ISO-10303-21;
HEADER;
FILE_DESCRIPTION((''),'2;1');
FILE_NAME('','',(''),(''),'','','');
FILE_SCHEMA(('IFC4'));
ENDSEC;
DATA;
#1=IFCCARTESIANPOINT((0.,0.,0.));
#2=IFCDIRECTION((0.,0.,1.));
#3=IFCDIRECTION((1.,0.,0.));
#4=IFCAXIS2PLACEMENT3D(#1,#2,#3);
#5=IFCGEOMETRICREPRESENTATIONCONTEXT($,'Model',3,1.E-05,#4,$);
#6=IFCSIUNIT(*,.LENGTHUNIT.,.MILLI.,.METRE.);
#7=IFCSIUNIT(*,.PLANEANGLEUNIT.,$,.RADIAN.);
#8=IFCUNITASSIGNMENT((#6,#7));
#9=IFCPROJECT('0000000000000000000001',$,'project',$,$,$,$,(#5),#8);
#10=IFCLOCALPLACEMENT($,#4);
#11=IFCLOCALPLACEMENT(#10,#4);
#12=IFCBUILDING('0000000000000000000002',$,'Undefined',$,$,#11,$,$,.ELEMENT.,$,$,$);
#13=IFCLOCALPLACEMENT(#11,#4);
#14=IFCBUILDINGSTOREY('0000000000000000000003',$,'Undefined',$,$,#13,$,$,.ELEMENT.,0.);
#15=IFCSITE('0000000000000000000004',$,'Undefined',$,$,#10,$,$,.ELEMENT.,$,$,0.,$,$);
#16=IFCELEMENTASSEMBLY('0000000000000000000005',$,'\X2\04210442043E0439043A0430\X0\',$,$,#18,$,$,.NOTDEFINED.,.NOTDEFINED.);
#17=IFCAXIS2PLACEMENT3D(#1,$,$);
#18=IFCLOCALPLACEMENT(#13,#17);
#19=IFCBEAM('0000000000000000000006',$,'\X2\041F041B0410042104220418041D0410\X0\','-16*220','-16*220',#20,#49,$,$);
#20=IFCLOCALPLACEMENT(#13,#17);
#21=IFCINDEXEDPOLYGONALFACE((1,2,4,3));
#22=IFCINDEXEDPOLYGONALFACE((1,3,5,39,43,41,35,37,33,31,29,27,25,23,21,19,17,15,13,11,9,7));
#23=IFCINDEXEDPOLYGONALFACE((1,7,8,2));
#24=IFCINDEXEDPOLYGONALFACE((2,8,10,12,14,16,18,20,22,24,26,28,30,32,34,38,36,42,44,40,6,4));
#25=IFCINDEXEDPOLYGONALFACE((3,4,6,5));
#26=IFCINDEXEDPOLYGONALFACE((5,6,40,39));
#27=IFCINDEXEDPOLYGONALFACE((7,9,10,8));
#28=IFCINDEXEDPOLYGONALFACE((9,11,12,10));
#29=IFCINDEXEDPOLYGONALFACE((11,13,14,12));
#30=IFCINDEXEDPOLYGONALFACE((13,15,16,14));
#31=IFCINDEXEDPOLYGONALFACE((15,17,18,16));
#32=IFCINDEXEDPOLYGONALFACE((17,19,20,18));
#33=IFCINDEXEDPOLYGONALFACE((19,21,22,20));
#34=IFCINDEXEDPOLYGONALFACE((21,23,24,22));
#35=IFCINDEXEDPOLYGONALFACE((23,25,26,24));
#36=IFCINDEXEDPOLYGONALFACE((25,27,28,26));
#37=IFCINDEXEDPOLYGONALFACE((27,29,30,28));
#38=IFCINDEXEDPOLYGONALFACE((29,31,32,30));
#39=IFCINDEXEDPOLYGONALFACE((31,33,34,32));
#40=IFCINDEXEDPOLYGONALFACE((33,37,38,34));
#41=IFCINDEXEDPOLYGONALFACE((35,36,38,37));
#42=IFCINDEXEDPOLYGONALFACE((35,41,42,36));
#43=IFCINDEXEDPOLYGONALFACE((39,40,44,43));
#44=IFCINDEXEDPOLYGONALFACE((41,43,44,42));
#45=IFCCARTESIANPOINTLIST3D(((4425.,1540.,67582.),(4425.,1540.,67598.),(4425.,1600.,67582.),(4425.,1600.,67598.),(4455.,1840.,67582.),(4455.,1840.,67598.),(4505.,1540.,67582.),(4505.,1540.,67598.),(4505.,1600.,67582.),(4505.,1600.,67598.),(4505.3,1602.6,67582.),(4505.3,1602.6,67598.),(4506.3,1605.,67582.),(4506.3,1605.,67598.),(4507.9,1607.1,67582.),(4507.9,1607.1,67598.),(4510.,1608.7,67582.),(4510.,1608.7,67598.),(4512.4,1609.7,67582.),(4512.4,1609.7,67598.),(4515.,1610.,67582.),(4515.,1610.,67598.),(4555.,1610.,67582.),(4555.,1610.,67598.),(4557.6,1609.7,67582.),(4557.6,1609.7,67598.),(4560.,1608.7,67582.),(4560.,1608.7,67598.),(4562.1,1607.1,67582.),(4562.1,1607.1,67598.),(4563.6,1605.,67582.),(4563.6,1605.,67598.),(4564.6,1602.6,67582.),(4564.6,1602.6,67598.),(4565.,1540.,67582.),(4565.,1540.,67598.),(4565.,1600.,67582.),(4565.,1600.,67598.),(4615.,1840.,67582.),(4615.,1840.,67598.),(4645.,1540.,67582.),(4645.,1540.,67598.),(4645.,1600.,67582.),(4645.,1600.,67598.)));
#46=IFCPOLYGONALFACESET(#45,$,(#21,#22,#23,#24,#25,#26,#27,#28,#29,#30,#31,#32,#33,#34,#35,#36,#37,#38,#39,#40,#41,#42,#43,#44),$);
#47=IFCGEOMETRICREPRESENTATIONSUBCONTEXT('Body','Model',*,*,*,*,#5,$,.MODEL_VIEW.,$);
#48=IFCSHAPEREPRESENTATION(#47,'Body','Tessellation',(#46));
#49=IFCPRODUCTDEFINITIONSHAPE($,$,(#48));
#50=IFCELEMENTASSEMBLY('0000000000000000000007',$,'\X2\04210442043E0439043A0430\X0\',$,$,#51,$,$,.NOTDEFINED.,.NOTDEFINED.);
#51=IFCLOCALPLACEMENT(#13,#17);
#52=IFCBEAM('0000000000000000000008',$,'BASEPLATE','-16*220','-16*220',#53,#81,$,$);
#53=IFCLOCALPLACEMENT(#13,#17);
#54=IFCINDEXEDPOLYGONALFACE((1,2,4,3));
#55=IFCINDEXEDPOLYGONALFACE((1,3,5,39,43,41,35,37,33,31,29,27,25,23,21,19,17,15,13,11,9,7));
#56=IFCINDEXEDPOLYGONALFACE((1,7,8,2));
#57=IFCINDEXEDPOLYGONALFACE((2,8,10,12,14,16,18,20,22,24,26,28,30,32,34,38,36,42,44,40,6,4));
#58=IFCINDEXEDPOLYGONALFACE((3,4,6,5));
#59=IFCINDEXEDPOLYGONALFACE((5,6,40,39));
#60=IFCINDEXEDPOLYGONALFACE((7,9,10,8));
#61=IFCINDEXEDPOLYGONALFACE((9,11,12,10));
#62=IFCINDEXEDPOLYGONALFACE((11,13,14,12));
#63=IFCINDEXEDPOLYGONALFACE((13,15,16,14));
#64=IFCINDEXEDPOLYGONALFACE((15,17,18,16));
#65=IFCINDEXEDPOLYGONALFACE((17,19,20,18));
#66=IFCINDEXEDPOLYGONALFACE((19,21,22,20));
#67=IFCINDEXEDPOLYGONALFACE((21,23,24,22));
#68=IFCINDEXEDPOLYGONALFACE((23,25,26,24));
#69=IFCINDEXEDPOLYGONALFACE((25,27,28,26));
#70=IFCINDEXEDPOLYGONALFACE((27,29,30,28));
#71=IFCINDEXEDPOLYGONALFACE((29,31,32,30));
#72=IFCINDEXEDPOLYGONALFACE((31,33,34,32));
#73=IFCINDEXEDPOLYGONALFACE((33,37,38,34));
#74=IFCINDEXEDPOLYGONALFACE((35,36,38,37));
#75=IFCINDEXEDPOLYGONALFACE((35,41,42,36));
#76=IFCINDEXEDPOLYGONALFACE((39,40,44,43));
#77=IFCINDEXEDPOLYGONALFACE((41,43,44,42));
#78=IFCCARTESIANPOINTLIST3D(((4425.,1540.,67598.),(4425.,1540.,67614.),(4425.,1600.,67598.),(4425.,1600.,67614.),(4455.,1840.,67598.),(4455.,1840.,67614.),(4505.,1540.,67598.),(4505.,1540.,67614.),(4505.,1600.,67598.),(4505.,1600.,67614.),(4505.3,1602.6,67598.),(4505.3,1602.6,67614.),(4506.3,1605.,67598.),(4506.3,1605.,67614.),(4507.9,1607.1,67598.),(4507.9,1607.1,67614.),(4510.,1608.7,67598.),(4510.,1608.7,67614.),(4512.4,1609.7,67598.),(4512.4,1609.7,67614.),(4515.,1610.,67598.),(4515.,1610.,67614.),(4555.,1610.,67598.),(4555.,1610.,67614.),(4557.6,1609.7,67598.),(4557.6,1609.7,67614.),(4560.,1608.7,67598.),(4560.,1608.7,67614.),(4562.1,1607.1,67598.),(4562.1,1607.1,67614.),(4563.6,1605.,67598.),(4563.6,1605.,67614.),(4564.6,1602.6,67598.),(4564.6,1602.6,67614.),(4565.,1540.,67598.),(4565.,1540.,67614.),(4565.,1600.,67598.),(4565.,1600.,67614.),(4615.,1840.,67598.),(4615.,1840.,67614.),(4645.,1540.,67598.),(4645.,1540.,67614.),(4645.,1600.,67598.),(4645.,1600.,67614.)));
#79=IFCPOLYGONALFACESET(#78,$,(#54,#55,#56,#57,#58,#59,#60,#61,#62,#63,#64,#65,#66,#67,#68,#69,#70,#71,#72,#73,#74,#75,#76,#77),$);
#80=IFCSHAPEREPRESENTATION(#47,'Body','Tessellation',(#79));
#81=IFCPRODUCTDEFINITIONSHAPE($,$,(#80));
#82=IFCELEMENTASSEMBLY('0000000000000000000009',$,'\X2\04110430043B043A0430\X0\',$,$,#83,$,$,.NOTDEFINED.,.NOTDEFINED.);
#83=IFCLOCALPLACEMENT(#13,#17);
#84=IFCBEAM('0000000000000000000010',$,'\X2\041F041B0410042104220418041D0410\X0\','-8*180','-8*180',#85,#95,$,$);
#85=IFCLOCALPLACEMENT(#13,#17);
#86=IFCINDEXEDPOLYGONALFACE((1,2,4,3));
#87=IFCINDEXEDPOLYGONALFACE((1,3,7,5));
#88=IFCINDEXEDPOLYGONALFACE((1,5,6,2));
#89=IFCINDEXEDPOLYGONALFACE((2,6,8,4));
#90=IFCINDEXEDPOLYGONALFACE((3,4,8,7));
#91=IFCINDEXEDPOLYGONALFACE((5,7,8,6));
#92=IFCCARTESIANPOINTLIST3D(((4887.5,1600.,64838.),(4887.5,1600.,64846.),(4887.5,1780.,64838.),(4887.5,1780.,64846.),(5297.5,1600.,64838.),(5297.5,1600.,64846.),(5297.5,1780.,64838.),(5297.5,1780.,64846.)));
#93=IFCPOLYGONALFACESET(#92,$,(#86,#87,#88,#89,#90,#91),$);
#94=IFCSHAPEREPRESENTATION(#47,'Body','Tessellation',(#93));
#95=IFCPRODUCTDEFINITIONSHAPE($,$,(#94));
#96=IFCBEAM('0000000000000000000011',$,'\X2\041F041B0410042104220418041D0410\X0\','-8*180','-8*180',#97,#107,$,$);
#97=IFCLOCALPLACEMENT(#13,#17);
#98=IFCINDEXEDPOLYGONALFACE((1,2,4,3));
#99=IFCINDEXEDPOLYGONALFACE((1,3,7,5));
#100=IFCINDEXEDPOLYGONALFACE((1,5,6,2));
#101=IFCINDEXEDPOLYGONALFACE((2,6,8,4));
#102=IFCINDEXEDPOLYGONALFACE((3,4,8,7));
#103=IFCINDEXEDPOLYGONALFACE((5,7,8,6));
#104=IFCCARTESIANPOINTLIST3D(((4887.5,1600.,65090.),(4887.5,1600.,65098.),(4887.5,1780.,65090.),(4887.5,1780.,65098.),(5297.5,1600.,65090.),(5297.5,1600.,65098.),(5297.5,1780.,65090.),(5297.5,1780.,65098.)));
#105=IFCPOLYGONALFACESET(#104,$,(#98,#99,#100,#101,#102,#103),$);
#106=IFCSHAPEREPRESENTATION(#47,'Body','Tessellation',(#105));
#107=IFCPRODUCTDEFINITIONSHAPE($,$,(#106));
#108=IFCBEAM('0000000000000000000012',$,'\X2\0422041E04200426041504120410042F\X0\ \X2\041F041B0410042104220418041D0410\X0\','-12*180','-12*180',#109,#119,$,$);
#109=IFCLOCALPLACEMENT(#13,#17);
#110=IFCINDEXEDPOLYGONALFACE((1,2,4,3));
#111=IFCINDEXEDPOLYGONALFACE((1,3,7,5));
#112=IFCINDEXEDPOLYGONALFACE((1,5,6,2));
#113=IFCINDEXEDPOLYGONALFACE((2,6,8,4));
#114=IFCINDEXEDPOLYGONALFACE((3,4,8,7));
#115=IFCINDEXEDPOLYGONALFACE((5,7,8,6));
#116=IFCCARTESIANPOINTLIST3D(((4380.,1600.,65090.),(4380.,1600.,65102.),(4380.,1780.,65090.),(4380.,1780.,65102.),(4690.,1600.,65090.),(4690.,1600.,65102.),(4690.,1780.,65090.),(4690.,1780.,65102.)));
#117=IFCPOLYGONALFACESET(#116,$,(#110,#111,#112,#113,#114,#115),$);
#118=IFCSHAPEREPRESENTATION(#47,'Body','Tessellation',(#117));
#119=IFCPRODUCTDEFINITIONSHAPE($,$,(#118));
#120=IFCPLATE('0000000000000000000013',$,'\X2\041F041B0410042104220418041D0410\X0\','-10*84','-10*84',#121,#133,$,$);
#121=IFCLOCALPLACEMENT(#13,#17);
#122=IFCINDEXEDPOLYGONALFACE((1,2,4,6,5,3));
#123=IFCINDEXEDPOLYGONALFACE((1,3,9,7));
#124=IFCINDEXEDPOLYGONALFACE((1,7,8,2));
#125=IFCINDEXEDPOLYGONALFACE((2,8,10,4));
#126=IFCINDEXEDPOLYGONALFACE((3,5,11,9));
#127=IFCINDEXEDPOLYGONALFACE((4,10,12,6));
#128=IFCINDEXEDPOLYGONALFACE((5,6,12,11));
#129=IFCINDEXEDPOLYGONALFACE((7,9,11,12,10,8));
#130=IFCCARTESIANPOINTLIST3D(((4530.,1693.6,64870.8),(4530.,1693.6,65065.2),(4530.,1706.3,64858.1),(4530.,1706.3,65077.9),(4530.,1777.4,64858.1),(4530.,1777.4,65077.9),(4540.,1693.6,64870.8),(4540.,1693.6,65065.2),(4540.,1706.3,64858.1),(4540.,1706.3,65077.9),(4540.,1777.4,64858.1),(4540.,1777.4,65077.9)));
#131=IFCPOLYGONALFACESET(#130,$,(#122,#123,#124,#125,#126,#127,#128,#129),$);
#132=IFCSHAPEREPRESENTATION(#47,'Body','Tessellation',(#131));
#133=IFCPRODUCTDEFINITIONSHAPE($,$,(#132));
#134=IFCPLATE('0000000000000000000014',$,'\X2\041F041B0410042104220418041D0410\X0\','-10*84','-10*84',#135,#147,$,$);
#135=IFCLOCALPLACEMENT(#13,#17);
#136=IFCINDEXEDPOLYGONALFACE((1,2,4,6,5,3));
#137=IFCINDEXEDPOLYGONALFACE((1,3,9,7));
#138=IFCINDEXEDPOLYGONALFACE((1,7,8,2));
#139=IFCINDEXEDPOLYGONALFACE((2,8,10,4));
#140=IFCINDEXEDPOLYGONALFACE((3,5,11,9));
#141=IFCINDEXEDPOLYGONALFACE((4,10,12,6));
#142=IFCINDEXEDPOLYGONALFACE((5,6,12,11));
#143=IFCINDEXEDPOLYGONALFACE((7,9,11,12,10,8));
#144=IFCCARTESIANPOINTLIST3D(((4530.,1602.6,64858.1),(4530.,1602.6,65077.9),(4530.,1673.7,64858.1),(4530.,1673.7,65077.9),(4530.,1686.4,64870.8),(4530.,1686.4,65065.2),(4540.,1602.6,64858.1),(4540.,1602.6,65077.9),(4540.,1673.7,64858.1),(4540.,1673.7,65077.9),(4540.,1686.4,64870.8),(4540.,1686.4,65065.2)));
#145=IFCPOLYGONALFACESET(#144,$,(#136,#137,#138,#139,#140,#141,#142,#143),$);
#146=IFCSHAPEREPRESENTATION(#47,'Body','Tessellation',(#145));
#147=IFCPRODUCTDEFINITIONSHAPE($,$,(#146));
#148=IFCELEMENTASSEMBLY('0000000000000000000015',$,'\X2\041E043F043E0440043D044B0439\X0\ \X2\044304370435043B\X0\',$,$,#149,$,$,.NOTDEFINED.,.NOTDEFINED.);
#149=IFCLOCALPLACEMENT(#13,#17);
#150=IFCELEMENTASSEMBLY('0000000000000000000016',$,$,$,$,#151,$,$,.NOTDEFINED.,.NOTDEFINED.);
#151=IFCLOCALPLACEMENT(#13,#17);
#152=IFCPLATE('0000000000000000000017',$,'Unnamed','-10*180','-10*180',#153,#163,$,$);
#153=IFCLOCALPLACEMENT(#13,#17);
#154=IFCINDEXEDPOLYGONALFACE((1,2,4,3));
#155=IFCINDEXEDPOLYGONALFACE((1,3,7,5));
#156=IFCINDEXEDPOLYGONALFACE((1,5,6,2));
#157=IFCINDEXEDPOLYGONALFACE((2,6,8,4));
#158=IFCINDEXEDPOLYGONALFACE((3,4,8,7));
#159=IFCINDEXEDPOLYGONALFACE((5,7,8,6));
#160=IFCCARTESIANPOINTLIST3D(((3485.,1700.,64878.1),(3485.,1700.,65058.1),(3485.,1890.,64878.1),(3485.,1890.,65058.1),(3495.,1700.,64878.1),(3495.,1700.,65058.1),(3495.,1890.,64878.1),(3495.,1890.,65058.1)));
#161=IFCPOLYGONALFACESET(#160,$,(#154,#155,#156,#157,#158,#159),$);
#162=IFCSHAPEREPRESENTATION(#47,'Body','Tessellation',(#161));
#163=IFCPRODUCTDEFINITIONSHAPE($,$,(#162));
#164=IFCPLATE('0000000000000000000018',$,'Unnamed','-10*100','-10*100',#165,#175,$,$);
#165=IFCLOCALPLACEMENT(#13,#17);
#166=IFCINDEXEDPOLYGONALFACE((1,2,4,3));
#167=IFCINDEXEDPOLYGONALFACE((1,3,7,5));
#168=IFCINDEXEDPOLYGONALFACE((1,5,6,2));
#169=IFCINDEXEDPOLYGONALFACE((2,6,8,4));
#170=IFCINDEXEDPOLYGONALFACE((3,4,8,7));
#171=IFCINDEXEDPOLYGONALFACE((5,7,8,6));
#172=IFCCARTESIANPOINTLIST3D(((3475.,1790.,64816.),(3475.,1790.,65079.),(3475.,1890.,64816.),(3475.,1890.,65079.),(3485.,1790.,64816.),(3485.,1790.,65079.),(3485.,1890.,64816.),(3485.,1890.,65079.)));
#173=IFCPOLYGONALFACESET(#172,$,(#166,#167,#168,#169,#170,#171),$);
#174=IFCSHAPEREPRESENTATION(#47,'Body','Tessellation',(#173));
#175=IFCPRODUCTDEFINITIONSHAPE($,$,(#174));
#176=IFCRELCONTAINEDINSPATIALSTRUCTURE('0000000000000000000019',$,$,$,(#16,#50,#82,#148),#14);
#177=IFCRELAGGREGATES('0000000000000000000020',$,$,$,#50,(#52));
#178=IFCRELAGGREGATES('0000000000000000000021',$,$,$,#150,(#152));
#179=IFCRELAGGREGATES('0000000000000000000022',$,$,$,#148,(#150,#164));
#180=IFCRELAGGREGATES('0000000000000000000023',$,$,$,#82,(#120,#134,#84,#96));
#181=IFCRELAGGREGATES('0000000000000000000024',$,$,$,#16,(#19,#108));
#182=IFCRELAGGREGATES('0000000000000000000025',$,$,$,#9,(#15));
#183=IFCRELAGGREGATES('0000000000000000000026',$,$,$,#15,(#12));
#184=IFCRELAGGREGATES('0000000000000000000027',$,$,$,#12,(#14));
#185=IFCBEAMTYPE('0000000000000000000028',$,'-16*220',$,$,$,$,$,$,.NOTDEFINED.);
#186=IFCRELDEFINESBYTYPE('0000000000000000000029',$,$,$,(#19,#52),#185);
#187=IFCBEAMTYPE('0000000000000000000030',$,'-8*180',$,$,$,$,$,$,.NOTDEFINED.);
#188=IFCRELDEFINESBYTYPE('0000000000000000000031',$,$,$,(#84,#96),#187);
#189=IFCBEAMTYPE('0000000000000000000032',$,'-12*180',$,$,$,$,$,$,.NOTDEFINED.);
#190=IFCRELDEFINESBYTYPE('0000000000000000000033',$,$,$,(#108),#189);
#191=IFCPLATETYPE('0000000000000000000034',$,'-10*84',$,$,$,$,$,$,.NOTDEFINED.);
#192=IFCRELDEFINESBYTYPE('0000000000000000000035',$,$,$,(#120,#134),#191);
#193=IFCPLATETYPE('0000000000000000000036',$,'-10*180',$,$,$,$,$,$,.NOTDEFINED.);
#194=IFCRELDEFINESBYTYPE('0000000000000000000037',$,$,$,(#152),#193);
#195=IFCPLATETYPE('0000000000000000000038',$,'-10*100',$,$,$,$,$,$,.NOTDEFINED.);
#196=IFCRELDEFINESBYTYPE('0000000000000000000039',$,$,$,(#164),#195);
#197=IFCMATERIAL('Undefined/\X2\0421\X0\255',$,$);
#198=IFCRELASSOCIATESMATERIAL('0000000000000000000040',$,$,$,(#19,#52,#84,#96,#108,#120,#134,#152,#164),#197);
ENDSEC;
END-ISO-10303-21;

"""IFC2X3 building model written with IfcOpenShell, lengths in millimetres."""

from ifc_helpers import new_model, si_unit, frame, frame_2d, origin_with_axes, origin_2d_with_axis, place, context, subcontext, project, spatial, polyline, circle_curve, parameter, trimmed, segment, composite_curve, rectangle, outline, extrude, boolean, material, type_object, element, aggregate, save


model = new_model("IFC2X3")

# Units and contexts
model_context = context("Model", 3, precision=1e-05, world=origin_with_axes())
body_context = subcontext(model_context, "Body", "Model", "MODEL_VIEW")
ifc_project = project(units=[si_unit("LENGTHUNIT", "METRE", prefix="MILLI"), si_unit("PLANEANGLEUNIT", "RADIAN")], contexts=[model_context])

# Site, building, storey
site_placement = place(None, origin_with_axes())
site = spatial("IfcSite", under=ifc_project, at=site_placement, Name="Undefined", CompositionType="ELEMENT", RefElevation=0.0)
building_placement = place(site_placement, origin_with_axes())
building = spatial("IfcBuilding", under=site, at=building_placement, Name="Undefined", CompositionType="ELEMENT")
storey_placement = place(building_placement, origin_with_axes())
storey = spatial("IfcBuildingStorey", under=building, at=storey_placement, Name="Undefined", CompositionType="ELEMENT", Elevation=0.0)

# Element assemblies, beams
assembly_1_placement = place(storey_placement, origin_with_axes())
assembly_1 = element("IfcElementAssembly", 1, at=assembly_1_placement, inside=storey, Name="Стойка", AssemblyPlace="NOTDEFINED", PredefinedType="NOTDEFINED")
ifc_material_1 = material(Name="Undefined/С255")
beam_type_1 = type_object("IfcBeamType", Name="-16*220", PredefinedType="NOTDEFINED")
beam_1_placement = place(assembly_1_placement, frame((4535.0, 1540.0, 67590.0), z_axis=(-1.0, 0.0, 0.000008), x_axis=(0.0, 1.0, 0.0)))
beam_1 = element("IfcBeam", 2, at=beam_1_placement, type_object=beam_type_1, material=ifc_material_1, Name="ПЛАСТИНА", Description="-16*220", ObjectType="-16*220", context=body_context, shape_type="CSG", body=[
    boolean("DIFFERENCE", boolean("DIFFERENCE", boolean("DIFFERENCE", extrude(rectangle(XDim=16.0, YDim=220.0, at=origin_2d_with_axis()), frame((300.0, 0.0, 0.0), z_axis=(-1.0, 0.0, 0.0), x_axis=(0.0, -1.0, 0.0)), (0.0, 0.0, 1.0), 300.0), extrude(outline(polyline([(0.0, 0.0), (30.0, 0.0), (0.0, 240.0), (0.0, 0.0)])), frame((300.0, 11.0, -110.0), z_axis=(0.0, -1.0, 0.0), x_axis=(0.0, 0.0, 1.0)), (0.0, 0.0, 1.0), 22.0)), extrude(outline(polyline([(0.0, 0.0), (30.0, 0.0), (30.0, 240.0), (0.0, 0.0)])), frame((300.0, 11.0, 80.0), z_axis=(0.0, -1.0, 0.0), x_axis=(0.0, 0.0, 1.0)), (0.0, 0.0, 1.0), 22.0)), extrude(outline(composite_curve([segment(polyline([(0.0, 0.0), (60.0, 0.0)]), True, "CONTINUOUS"), segment(trimmed(circle_curve(frame_2d((60.0, 10.0), x_axis=(0.0, -1.0)), 10.0), [parameter(0.0)], [parameter(1.5708)], True, "PARAMETER"), True, "CONTINUOUS"), segment(polyline([(70.0, 10.0), (70.0, 50.0)]), True, "CONTINUOUS"), segment(trimmed(circle_curve(frame_2d((60.0, 50.0), x_axis=(1.0, 0.0)), 10.0), [parameter(0.0)], [parameter(1.5708)], True, "PARAMETER"), True, "CONTINUOUS"), segment(polyline([(60.0, 60.0), (0.0, 60.0), (0.0, 0.0)]), True, "DISCONTINUOUS")], self_intersect=False)), frame((0.0, -11.0, 30.0), z_axis=(0.0, 1.0, 0.000004), x_axis=(1.0, 0.0, 0.0)), (0.0, 0.0, 1.0), 22.0)),
])
assembly_2_placement = place(storey_placement, origin_with_axes())
assembly_2 = element("IfcElementAssembly", 3, at=assembly_2_placement, inside=storey, Name="Стойка", AssemblyPlace="NOTDEFINED", PredefinedType="NOTDEFINED")
beam_2_placement = place(assembly_2_placement, frame((4535.0, 1540.0, 67606.0), z_axis=(-1.0, 0.0, 0.000008), x_axis=(0.0, 1.0, 0.0)))
beam_2 = element("IfcBeam", 4, at=beam_2_placement, type_object=beam_type_1, material=ifc_material_1, Name="BASEPLATE", Description="-16*220", ObjectType="-16*220", context=body_context, shape_type="CSG", body=[
    boolean("DIFFERENCE", boolean("DIFFERENCE", boolean("DIFFERENCE", extrude(rectangle(XDim=16.0, YDim=220.0, at=origin_2d_with_axis()), frame((300.0, 0.0, 0.0), z_axis=(-1.0, 0.0, 0.0), x_axis=(0.0, -1.0, 0.0)), (0.0, 0.0, 1.0), 300.0), extrude(outline(polyline([(0.0, 0.0), (30.0, 0.0), (0.0, 240.0), (0.0, 0.0)])), frame((300.0, 11.0, -110.0), z_axis=(0.0, -1.0, 0.0), x_axis=(0.0, 0.0, 1.0)), (0.0, 0.0, 1.0), 22.0)), extrude(outline(polyline([(0.0, 0.0), (30.0, 0.0), (30.0, 240.0), (0.0, 0.0)])), frame((300.0, 11.0, 80.0), z_axis=(0.0, -1.0, 0.0), x_axis=(0.0, 0.0, 1.0)), (0.0, 0.0, 1.0), 22.0)), extrude(outline(composite_curve([segment(polyline([(0.0, 0.0), (60.0, 0.0)]), True, "CONTINUOUS"), segment(trimmed(circle_curve(frame_2d((60.0, 10.0), x_axis=(0.0, -1.0)), 10.0), [parameter(0.0)], [parameter(1.5708)], True, "PARAMETER"), True, "CONTINUOUS"), segment(polyline([(70.0, 10.0), (70.0, 50.0)]), True, "CONTINUOUS"), segment(trimmed(circle_curve(frame_2d((60.0, 50.0), x_axis=(1.0, 0.0)), 10.0), [parameter(0.0)], [parameter(1.5708)], True, "PARAMETER"), True, "CONTINUOUS"), segment(polyline([(60.0, 60.0), (0.0, 60.0), (0.0, 0.0)]), True, "DISCONTINUOUS")], self_intersect=False)), frame((0.0, -11.0, 30.0), z_axis=(0.0, 1.0, 0.000008), x_axis=(1.0, 0.0, 0.0)), (0.0, 0.0, 1.0), 22.0)),
])
aggregate(assembly_2, [beam_2])

# Element assembly, beams
assembly_3_placement = place(storey_placement, origin_with_axes())
assembly_3 = element("IfcElementAssembly", 5, at=assembly_3_placement, inside=storey, Name="Балка", AssemblyPlace="NOTDEFINED", PredefinedType="NOTDEFINED")
beam_type_2 = type_object("IfcBeamType", Name="-8*180", PredefinedType="NOTDEFINED")
beam_3_placement = place(assembly_3_placement, frame((4887.5, 1690.0, 64842.0), z_axis=(0.0, -1.0, 0.0), x_axis=(1.0, 0.0, 0.0)))
beam_3 = element("IfcBeam", 6, at=beam_3_placement, type_object=beam_type_2, material=ifc_material_1, Name="ПЛАСТИНА", Description="-8*180", ObjectType="-8*180", context=body_context, shape_type="SweptSolid", body=[
    extrude(rectangle(XDim=8.0, YDim=180.0, at=origin_2d_with_axis()), frame((410.0, 0.0, 0.0), z_axis=(-1.0, 0.0, 0.0), x_axis=(0.0, -1.0, 0.0)), (0.0, 0.0, 1.0), 410.0),
])
beam_4_placement = place(assembly_3_placement, frame((4887.5, 1690.0, 65094.0), z_axis=(0.0, -1.0, 0.0), x_axis=(1.0, 0.0, 0.0)))
beam_4 = element("IfcBeam", 7, at=beam_4_placement, type_object=beam_type_2, material=ifc_material_1, Name="ПЛАСТИНА", Description="-8*180", ObjectType="-8*180", context=body_context, shape_type="SweptSolid", body=[
    extrude(rectangle(XDim=8.0, YDim=180.0, at=origin_2d_with_axis()), frame((410.0, 0.0, 0.0), z_axis=(-1.0, 0.0, 0.0), x_axis=(0.0, -1.0, 0.0)), (0.0, 0.0, 1.0), 410.0),
])

# Beam
beam_type_3 = type_object("IfcBeamType", Name="-12*180", PredefinedType="NOTDEFINED")
beam_5_placement = place(assembly_1_placement, frame((4380.0, 1690.0, 65096.0), z_axis=(0.0, 1.0, 0.0), x_axis=(1.0, 0.0, 0.0)))
beam_5 = element("IfcBeam", 8, at=beam_5_placement, type_object=beam_type_3, material=ifc_material_1, Name="ТОРЦЕВАЯ ПЛАСТИНА", Description="-12*180", ObjectType="-12*180", context=body_context, shape_type="SweptSolid", body=[
    extrude(rectangle(XDim=12.0, YDim=180.0, at=origin_2d_with_axis()), frame((310.0, 0.0, 0.0), z_axis=(-1.0, 0.0, 0.0), x_axis=(0.0, -1.0, 0.0)), (0.0, 0.0, 1.0), 310.0),
])

# Plates
plate_type_1 = type_object("IfcPlateType", Name="-10*84", PredefinedType="NOTDEFINED")
plate_1_placement = place(assembly_3_placement, frame((4535.0, 1693.6, 65077.9), z_axis=(-1.0, 0.0, 0.0), x_axis=(0.0, 1.0, 0.0)))
plate_1 = element("IfcPlate", 9, at=plate_1_placement, type_object=plate_type_1, material=ifc_material_1, Name="ПЛАСТИНА", Description="-10*84", ObjectType="-10*84", context=body_context, shape_type="SweptSolid", body=[
    extrude(outline(polyline([(0.0, 12.7), (12.7, 0.0), (83.8, 0.0), (83.8, 219.8), (12.7, 219.8), (0.0, 207.1), (0.0, 12.7)])), frame((0.0, 0.0, -5.0), z_axis=(0.0, 0.0, 1.0), x_axis=(1.0, 0.0, 0.0)), (0.0, 0.0, 1.0), 10.0),
])
plate_2_placement = place(assembly_3_placement, frame((4535.0, 1602.6, 65077.9), z_axis=(-1.0, 0.0, 0.0), x_axis=(0.0, 1.0, 0.0)))
plate_2 = element("IfcPlate", 10, at=plate_2_placement, type_object=plate_type_1, material=ifc_material_1, Name="ПЛАСТИНА", Description="-10*84", ObjectType="-10*84", context=body_context, shape_type="SweptSolid", body=[
    extrude(outline(polyline([(0.0, 0.0), (71.1, 0.0), (83.8, 12.7), (83.8, 207.1), (71.1, 219.8), (0.0, 219.8), (0.0, 0.0)])), frame((0.0, 0.0, -5.0), z_axis=(0.0, 0.0, 1.0), x_axis=(1.0, 0.0, 0.0)), (0.0, 0.0, 1.0), 10.0),
])

# Element assemblies, plates
assembly_4_placement = place(storey_placement, origin_with_axes())
assembly_4 = element("IfcElementAssembly", 11, at=assembly_4_placement, inside=storey, Name="Опорный узел", AssemblyPlace="NOTDEFINED", PredefinedType="NOTDEFINED")
assembly_5_placement = place(assembly_4_placement, origin_with_axes())
assembly_5 = element("IfcElementAssembly", 12, at=assembly_5_placement, AssemblyPlace="NOTDEFINED", PredefinedType="NOTDEFINED")
plate_type_2 = type_object("IfcPlateType", Name="-10*180", PredefinedType="NOTDEFINED")
plate_3_placement = place(assembly_5_placement, frame((3490.0, 1890.0, 65058.1), z_axis=(1.0, 0.0, 0.0), x_axis=(0.0, -1.0, 0.0)))
plate_3 = element("IfcPlate", 13, at=plate_3_placement, type_object=plate_type_2, material=ifc_material_1, Name="Unnamed", Description="-10*180", ObjectType="-10*180", context=body_context, shape_type="SweptSolid", body=[
    extrude(outline(polyline([(0.0, 0.0), (190.0, 0.0), (190.0, 180.0), (0.0, 180.0), (0.0, 0.0)])), frame((0.0, 0.0, -5.0), z_axis=(0.0, 0.0, 1.0), x_axis=(1.0, 0.0, 0.0)), (0.0, 0.0, 1.0), 10.0),
])
aggregate(assembly_5, [plate_3])
plate_type_3 = type_object("IfcPlateType", Name="-10*100", PredefinedType="NOTDEFINED")
plate_4_placement = place(assembly_4_placement, frame((3480.0, 1790.0, 64816.0), z_axis=(-1.0, 0.0, 0.0), x_axis=(0.0, 0.0, 1.0)))
plate_4 = element("IfcPlate", 14, at=plate_4_placement, type_object=plate_type_3, material=ifc_material_1, Name="Unnamed", Description="-10*100", ObjectType="-10*100", context=body_context, shape_type="SweptSolid", body=[
    extrude(outline(polyline([(0.0, 0.0), (263.0, 0.0), (263.0, 100.0), (0.0, 100.0), (0.0, 0.0)])), frame((0.0, 0.0, -5.0), z_axis=(0.0, 0.0, 1.0), x_axis=(1.0, 0.0, 0.0)), (0.0, 0.0, 1.0), 10.0),
])

aggregate(assembly_4, [assembly_5, plate_4])

aggregate(assembly_3, [plate_1, plate_2, beam_3, beam_4])
aggregate(assembly_1, [beam_1, beam_5])

save(model, "model.ifc")
